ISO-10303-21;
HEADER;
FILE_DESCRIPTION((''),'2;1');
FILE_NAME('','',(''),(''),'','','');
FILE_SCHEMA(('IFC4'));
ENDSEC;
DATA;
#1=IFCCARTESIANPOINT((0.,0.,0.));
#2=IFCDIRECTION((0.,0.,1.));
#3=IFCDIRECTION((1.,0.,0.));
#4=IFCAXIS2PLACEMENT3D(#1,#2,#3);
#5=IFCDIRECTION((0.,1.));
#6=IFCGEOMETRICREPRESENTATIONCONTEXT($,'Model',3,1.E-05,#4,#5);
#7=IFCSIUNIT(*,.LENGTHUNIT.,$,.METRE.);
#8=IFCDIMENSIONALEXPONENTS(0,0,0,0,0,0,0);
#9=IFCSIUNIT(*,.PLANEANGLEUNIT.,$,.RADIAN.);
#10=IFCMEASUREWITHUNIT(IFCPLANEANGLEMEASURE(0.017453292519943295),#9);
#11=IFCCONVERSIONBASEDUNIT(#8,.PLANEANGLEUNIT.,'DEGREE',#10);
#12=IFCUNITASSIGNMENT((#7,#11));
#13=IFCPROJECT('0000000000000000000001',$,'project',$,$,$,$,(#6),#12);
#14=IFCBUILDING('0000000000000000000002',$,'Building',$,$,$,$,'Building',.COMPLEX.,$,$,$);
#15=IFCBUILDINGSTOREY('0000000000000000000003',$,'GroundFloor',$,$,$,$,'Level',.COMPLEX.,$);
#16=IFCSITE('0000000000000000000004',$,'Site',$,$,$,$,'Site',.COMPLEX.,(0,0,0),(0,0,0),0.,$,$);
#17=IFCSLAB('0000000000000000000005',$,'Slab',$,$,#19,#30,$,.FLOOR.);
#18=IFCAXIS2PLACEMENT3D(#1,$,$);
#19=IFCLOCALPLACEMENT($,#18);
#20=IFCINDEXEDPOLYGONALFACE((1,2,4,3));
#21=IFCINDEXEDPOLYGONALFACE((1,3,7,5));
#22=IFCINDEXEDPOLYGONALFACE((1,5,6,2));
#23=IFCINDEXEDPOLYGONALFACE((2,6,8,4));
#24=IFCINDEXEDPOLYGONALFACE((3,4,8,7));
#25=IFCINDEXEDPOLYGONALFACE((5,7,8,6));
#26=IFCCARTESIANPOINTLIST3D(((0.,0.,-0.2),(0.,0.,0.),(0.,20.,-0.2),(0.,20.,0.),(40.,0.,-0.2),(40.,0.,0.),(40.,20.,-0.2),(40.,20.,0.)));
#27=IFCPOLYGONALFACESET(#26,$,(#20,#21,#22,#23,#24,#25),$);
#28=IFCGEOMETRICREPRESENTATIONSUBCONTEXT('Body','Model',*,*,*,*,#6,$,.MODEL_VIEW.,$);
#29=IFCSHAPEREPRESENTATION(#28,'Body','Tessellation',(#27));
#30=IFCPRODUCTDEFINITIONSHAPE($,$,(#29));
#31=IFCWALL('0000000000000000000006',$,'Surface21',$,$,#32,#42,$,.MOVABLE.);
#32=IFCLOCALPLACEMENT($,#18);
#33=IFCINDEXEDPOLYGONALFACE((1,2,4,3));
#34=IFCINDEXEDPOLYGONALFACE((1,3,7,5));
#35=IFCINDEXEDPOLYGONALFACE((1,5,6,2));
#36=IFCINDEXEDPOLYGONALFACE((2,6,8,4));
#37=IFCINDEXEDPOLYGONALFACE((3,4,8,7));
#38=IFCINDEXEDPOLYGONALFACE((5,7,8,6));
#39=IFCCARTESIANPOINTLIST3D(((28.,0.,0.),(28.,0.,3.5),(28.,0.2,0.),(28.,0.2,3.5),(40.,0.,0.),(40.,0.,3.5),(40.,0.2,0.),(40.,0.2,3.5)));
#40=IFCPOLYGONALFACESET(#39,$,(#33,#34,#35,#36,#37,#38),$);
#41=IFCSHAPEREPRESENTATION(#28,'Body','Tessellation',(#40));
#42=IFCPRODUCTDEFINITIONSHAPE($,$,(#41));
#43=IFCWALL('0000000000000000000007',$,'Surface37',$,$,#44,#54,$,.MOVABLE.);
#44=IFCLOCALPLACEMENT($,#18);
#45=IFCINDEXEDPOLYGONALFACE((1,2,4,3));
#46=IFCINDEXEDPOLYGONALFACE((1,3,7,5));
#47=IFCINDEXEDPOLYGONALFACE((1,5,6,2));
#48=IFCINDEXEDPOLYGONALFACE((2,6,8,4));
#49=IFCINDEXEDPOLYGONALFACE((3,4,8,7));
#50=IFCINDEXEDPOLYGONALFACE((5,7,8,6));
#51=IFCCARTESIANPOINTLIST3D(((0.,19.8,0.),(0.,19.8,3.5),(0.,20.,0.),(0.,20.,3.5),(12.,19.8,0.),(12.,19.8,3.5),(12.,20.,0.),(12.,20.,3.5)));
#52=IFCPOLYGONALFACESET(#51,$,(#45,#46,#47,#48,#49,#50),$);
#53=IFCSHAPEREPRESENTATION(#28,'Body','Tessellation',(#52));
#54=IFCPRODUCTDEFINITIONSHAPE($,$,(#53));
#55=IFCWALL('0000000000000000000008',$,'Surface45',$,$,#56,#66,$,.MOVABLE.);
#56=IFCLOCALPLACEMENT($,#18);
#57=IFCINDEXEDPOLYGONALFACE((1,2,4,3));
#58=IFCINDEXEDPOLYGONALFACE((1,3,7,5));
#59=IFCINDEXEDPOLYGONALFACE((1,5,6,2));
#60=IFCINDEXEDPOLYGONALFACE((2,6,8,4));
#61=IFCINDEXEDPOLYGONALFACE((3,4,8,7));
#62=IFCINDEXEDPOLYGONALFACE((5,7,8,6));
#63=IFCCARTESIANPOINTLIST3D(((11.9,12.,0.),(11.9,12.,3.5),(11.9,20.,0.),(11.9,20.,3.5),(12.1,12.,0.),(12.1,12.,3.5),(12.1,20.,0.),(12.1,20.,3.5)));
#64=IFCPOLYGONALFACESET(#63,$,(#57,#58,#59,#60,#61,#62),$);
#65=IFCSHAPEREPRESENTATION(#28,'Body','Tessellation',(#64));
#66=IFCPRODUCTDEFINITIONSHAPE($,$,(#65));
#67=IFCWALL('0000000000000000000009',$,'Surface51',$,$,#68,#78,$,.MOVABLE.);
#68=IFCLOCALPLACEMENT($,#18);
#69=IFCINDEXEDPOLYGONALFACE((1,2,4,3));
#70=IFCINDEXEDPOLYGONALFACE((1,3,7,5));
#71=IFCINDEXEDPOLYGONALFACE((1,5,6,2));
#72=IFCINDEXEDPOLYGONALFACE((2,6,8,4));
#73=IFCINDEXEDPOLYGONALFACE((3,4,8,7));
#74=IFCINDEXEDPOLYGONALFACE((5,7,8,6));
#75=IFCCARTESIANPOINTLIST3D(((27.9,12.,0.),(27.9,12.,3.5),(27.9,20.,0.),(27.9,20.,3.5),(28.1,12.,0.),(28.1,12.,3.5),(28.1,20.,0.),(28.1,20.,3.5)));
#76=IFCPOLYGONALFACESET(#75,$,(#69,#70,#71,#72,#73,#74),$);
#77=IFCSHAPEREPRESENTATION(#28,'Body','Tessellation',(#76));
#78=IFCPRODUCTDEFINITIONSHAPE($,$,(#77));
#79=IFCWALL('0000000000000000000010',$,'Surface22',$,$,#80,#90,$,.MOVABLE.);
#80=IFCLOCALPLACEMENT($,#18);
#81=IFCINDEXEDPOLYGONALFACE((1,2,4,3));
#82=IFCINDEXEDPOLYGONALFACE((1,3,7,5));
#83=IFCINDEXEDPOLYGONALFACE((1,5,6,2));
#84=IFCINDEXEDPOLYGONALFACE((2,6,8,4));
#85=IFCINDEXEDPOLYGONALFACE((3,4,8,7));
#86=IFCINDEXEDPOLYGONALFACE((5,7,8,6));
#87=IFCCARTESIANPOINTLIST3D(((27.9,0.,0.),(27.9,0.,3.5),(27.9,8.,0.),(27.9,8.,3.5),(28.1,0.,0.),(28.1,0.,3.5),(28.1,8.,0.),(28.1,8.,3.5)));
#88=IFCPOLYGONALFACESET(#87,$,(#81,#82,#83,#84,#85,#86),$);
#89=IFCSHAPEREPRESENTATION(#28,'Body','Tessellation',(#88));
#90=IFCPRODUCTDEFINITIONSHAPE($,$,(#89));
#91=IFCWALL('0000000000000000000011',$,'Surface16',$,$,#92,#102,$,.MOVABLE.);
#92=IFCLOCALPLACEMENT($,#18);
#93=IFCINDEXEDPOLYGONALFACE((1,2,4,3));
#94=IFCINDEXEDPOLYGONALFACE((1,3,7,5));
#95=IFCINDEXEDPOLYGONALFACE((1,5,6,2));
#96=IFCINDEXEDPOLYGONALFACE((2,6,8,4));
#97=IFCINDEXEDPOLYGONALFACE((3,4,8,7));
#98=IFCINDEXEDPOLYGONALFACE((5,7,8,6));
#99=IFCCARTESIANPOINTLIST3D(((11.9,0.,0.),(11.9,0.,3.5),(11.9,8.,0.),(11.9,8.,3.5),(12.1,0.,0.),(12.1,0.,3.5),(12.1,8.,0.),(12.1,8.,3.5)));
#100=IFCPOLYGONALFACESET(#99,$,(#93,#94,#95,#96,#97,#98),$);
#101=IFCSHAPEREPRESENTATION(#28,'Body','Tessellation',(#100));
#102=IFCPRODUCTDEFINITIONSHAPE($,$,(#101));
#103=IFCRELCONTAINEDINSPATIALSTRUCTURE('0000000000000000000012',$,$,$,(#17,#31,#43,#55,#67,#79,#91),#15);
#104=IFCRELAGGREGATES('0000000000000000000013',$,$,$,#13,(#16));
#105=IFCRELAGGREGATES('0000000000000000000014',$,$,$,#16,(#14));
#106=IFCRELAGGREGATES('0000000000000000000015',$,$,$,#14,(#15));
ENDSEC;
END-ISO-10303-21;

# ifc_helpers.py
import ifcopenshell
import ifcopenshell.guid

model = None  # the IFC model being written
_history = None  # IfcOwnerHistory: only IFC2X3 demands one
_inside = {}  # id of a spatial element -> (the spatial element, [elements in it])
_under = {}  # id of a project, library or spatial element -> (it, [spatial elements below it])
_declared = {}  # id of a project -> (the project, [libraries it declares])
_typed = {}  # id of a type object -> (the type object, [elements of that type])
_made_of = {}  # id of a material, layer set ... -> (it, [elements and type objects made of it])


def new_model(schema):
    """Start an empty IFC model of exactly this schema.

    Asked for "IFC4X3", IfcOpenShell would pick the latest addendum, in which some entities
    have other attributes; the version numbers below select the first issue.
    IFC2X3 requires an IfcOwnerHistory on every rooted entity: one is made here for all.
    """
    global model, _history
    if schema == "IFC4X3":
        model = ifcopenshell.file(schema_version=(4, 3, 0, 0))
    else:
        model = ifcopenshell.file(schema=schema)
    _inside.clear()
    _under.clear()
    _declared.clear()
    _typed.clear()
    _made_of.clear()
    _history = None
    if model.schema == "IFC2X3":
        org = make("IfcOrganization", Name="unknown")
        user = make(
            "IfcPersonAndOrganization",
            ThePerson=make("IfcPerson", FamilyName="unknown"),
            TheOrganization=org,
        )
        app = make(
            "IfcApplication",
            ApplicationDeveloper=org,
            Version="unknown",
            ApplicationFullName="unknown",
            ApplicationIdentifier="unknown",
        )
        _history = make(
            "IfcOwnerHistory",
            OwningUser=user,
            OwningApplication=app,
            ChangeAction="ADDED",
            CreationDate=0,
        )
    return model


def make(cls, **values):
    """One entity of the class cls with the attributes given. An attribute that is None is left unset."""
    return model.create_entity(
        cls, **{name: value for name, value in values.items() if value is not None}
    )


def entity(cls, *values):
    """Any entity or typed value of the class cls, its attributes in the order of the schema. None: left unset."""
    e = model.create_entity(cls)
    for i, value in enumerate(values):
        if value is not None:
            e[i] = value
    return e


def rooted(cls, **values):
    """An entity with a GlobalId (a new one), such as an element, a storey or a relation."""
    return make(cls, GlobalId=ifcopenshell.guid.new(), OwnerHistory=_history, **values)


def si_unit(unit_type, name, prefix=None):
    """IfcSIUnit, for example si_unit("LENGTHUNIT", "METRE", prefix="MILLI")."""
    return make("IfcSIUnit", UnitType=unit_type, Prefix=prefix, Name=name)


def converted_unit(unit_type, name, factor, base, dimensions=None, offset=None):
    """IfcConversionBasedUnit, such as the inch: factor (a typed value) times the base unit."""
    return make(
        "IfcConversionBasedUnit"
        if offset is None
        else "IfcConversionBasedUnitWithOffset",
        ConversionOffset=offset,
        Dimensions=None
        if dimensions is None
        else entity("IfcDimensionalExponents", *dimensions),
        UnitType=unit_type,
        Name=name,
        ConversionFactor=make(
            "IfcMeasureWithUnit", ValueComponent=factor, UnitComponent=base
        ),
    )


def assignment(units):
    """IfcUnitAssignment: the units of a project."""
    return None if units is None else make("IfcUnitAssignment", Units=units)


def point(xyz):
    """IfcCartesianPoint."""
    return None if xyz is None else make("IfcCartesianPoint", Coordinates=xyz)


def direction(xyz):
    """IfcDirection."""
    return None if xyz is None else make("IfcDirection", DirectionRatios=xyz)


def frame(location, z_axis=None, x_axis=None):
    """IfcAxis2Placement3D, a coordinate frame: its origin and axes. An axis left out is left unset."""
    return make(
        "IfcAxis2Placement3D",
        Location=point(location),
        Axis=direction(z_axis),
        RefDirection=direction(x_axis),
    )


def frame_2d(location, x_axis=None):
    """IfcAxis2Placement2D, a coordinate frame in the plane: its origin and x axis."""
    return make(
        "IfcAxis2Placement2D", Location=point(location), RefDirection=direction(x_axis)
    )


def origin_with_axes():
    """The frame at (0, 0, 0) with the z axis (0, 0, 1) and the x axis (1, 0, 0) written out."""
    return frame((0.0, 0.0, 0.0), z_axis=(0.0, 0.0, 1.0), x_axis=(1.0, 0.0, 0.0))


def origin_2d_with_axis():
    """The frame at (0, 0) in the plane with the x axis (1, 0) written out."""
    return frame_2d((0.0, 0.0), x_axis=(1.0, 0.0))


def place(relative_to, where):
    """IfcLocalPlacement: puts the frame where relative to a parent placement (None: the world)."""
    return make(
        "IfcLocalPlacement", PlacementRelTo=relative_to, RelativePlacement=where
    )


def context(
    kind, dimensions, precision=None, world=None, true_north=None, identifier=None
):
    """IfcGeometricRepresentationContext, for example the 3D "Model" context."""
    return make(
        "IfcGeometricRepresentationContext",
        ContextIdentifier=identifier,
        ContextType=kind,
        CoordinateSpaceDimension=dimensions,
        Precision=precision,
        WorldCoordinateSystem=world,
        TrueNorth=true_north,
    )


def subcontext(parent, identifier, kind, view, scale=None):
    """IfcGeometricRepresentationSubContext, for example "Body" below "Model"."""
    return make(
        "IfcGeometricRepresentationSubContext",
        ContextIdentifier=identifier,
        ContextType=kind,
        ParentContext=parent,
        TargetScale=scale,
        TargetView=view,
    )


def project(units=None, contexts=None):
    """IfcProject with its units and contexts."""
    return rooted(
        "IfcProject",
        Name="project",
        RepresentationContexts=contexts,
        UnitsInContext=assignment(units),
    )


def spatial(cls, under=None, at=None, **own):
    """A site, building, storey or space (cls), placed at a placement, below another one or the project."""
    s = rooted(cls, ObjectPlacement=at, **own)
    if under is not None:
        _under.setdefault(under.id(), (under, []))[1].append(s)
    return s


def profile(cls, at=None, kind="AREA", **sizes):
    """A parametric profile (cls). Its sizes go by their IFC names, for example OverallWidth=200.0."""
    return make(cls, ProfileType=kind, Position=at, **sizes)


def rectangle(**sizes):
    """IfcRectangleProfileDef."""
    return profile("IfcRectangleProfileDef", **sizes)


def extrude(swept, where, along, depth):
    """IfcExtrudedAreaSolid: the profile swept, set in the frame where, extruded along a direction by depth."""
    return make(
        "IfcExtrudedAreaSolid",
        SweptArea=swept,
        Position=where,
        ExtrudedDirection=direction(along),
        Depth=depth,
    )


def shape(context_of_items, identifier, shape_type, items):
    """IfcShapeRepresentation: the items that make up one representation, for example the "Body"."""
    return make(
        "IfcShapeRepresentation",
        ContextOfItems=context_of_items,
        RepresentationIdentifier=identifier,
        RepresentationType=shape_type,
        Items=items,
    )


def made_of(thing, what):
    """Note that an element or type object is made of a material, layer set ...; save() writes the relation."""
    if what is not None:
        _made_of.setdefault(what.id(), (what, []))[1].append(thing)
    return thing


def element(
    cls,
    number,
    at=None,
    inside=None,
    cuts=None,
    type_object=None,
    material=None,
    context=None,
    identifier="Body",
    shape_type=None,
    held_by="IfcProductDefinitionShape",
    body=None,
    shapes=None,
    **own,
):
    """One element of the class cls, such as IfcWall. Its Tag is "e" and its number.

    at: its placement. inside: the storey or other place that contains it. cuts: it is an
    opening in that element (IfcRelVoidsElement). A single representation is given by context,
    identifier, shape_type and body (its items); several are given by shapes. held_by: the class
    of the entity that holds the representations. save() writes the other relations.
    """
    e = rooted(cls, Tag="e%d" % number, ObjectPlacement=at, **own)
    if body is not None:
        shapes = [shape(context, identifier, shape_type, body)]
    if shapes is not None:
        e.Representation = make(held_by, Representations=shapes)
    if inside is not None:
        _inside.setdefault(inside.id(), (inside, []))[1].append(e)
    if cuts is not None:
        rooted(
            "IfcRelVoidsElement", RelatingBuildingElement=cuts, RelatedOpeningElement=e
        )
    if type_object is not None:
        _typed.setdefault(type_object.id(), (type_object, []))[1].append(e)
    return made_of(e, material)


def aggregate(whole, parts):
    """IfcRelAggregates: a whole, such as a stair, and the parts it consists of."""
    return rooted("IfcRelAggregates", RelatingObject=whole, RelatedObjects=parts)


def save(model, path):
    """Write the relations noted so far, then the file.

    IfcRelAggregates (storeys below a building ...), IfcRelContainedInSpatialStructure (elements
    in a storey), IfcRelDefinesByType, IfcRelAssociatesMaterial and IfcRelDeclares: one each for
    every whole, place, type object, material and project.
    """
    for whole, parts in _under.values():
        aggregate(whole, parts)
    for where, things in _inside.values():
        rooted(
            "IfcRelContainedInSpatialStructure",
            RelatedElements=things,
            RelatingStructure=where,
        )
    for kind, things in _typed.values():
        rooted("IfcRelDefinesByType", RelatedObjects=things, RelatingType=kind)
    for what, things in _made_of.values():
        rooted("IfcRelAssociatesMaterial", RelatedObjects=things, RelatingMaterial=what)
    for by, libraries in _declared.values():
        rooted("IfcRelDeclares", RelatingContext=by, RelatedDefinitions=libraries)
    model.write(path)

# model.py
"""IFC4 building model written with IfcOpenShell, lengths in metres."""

from ifc_helpers import new_model, entity, si_unit, converted_unit, direction, frame, frame_2d, origin_with_axes, origin_2d_with_axis, place, context, subcontext, project, spatial, rectangle, extrude, element, save


model = new_model("IFC4")

# Units and contexts
model_context = context("Model", 3, precision=1e-05, world=origin_with_axes(), true_north=direction((0.0, 1.0)))
body_context = subcontext(model_context, "Body", "Model", "MODEL_VIEW")
ifc_project = project(units=[si_unit("LENGTHUNIT", "METRE"), converted_unit("PLANEANGLEUNIT", "DEGREE", entity("IfcPlaneAngleMeasure", 0.017453292519943295), si_unit("PLANEANGLEUNIT", "RADIAN"), dimensions=[0, 0, 0, 0, 0, 0, 0])], contexts=[model_context])

# Site, building, storey
site = spatial("IfcSite", under=ifc_project, Name="Site", LongName="Site", CompositionType="COMPLEX", RefLatitude=(0, 0, 0), RefLongitude=(0, 0, 0), RefElevation=0.0)
building = spatial("IfcBuilding", under=site, Name="Building", LongName="Building", CompositionType="COMPLEX")
storey = spatial("IfcBuildingStorey", under=building, Name="GroundFloor", LongName="Level", CompositionType="COMPLEX")

# Slab
placement = place(None, origin_with_axes())
element("IfcSlab", 1, at=placement, inside=storey, Name="Slab", PredefinedType="FLOOR", context=body_context, shape_type="SweptSolid", body=[
    extrude(rectangle(XDim=40.0, YDim=20.0, at=origin_2d_with_axis()), frame((20.0, 10.0, 0.0), z_axis=(0.0, 0.0, 1.0), x_axis=(1.0, 0.0, 0.0)), (0.0, 0.0, -1.0), 0.2),
])

# Walls
element("IfcWall", 2, at=placement, inside=storey, Name="Surface21", PredefinedType="MOVABLE", context=body_context, shape_type="SweptSolid", body=[
    extrude(rectangle(XDim=12.0, YDim=0.2, at=origin_2d_with_axis()), frame((34.0, 0.1, 0.0), z_axis=(0.0, 0.0, 1.0), x_axis=(1.0, 0.0, 0.0)), (0.0, 0.0, 1.0), 3.5),
])
element("IfcWall", 3, at=placement, inside=storey, Name="Surface37", PredefinedType="MOVABLE", context=body_context, shape_type="SweptSolid", body=[
    extrude(rectangle(XDim=12.0, YDim=0.2, at=origin_2d_with_axis()), frame((6.0, 19.9, 0.0), z_axis=(0.0, 0.0, 1.0), x_axis=(1.0, 0.0, 0.0)), (0.0, 0.0, 1.0), 3.5),
])
element("IfcWall", 4, at=placement, inside=storey, Name="Surface45", PredefinedType="MOVABLE", context=body_context, shape_type="SweptSolid", body=[
    extrude(rectangle(XDim=8.0, YDim=0.2, at=frame_2d((0.0, 0.0), x_axis=(0.0, 1.0))), frame((12.0, 16.0, 0.0), z_axis=(0.0, 0.0, 1.0), x_axis=(1.0, 0.0, 0.0)), (0.0, 0.0, 1.0), 3.5),
])
element("IfcWall", 5, at=placement, inside=storey, Name="Surface51", PredefinedType="MOVABLE", context=body_context, shape_type="SweptSolid", body=[
    extrude(rectangle(XDim=8.0, YDim=0.2, at=frame_2d((0.0, 0.0), x_axis=(0.0, 1.0))), frame((28.0, 16.0, 0.0), z_axis=(0.0, 0.0, 1.0), x_axis=(1.0, 0.0, 0.0)), (0.0, 0.0, 1.0), 3.5),
])
element("IfcWall", 6, at=placement, inside=storey, Name="Surface22", PredefinedType="MOVABLE", context=body_context, shape_type="SweptSolid", body=[
    extrude(rectangle(XDim=8.0, YDim=0.2, at=frame_2d((0.0, 0.0), x_axis=(0.0, 1.0))), frame((28.0, 4.0, 0.0), z_axis=(0.0, 0.0, 1.0), x_axis=(1.0, 0.0, 0.0)), (0.0, 0.0, 1.0), 3.5),
])
element("IfcWall", 7, at=placement, inside=storey, Name="Surface16", PredefinedType="MOVABLE", context=body_context, shape_type="SweptSolid", body=[
    extrude(rectangle(XDim=8.0, YDim=0.2, at=frame_2d((0.0, 0.0), x_axis=(0.0, 1.0))), frame((12.0, 4.0, 0.0), z_axis=(0.0, 0.0, 1.0), x_axis=(1.0, 0.0, 0.0)), (0.0, 0.0, 1.0), 3.5),
])

save(model, "model.ifc")
